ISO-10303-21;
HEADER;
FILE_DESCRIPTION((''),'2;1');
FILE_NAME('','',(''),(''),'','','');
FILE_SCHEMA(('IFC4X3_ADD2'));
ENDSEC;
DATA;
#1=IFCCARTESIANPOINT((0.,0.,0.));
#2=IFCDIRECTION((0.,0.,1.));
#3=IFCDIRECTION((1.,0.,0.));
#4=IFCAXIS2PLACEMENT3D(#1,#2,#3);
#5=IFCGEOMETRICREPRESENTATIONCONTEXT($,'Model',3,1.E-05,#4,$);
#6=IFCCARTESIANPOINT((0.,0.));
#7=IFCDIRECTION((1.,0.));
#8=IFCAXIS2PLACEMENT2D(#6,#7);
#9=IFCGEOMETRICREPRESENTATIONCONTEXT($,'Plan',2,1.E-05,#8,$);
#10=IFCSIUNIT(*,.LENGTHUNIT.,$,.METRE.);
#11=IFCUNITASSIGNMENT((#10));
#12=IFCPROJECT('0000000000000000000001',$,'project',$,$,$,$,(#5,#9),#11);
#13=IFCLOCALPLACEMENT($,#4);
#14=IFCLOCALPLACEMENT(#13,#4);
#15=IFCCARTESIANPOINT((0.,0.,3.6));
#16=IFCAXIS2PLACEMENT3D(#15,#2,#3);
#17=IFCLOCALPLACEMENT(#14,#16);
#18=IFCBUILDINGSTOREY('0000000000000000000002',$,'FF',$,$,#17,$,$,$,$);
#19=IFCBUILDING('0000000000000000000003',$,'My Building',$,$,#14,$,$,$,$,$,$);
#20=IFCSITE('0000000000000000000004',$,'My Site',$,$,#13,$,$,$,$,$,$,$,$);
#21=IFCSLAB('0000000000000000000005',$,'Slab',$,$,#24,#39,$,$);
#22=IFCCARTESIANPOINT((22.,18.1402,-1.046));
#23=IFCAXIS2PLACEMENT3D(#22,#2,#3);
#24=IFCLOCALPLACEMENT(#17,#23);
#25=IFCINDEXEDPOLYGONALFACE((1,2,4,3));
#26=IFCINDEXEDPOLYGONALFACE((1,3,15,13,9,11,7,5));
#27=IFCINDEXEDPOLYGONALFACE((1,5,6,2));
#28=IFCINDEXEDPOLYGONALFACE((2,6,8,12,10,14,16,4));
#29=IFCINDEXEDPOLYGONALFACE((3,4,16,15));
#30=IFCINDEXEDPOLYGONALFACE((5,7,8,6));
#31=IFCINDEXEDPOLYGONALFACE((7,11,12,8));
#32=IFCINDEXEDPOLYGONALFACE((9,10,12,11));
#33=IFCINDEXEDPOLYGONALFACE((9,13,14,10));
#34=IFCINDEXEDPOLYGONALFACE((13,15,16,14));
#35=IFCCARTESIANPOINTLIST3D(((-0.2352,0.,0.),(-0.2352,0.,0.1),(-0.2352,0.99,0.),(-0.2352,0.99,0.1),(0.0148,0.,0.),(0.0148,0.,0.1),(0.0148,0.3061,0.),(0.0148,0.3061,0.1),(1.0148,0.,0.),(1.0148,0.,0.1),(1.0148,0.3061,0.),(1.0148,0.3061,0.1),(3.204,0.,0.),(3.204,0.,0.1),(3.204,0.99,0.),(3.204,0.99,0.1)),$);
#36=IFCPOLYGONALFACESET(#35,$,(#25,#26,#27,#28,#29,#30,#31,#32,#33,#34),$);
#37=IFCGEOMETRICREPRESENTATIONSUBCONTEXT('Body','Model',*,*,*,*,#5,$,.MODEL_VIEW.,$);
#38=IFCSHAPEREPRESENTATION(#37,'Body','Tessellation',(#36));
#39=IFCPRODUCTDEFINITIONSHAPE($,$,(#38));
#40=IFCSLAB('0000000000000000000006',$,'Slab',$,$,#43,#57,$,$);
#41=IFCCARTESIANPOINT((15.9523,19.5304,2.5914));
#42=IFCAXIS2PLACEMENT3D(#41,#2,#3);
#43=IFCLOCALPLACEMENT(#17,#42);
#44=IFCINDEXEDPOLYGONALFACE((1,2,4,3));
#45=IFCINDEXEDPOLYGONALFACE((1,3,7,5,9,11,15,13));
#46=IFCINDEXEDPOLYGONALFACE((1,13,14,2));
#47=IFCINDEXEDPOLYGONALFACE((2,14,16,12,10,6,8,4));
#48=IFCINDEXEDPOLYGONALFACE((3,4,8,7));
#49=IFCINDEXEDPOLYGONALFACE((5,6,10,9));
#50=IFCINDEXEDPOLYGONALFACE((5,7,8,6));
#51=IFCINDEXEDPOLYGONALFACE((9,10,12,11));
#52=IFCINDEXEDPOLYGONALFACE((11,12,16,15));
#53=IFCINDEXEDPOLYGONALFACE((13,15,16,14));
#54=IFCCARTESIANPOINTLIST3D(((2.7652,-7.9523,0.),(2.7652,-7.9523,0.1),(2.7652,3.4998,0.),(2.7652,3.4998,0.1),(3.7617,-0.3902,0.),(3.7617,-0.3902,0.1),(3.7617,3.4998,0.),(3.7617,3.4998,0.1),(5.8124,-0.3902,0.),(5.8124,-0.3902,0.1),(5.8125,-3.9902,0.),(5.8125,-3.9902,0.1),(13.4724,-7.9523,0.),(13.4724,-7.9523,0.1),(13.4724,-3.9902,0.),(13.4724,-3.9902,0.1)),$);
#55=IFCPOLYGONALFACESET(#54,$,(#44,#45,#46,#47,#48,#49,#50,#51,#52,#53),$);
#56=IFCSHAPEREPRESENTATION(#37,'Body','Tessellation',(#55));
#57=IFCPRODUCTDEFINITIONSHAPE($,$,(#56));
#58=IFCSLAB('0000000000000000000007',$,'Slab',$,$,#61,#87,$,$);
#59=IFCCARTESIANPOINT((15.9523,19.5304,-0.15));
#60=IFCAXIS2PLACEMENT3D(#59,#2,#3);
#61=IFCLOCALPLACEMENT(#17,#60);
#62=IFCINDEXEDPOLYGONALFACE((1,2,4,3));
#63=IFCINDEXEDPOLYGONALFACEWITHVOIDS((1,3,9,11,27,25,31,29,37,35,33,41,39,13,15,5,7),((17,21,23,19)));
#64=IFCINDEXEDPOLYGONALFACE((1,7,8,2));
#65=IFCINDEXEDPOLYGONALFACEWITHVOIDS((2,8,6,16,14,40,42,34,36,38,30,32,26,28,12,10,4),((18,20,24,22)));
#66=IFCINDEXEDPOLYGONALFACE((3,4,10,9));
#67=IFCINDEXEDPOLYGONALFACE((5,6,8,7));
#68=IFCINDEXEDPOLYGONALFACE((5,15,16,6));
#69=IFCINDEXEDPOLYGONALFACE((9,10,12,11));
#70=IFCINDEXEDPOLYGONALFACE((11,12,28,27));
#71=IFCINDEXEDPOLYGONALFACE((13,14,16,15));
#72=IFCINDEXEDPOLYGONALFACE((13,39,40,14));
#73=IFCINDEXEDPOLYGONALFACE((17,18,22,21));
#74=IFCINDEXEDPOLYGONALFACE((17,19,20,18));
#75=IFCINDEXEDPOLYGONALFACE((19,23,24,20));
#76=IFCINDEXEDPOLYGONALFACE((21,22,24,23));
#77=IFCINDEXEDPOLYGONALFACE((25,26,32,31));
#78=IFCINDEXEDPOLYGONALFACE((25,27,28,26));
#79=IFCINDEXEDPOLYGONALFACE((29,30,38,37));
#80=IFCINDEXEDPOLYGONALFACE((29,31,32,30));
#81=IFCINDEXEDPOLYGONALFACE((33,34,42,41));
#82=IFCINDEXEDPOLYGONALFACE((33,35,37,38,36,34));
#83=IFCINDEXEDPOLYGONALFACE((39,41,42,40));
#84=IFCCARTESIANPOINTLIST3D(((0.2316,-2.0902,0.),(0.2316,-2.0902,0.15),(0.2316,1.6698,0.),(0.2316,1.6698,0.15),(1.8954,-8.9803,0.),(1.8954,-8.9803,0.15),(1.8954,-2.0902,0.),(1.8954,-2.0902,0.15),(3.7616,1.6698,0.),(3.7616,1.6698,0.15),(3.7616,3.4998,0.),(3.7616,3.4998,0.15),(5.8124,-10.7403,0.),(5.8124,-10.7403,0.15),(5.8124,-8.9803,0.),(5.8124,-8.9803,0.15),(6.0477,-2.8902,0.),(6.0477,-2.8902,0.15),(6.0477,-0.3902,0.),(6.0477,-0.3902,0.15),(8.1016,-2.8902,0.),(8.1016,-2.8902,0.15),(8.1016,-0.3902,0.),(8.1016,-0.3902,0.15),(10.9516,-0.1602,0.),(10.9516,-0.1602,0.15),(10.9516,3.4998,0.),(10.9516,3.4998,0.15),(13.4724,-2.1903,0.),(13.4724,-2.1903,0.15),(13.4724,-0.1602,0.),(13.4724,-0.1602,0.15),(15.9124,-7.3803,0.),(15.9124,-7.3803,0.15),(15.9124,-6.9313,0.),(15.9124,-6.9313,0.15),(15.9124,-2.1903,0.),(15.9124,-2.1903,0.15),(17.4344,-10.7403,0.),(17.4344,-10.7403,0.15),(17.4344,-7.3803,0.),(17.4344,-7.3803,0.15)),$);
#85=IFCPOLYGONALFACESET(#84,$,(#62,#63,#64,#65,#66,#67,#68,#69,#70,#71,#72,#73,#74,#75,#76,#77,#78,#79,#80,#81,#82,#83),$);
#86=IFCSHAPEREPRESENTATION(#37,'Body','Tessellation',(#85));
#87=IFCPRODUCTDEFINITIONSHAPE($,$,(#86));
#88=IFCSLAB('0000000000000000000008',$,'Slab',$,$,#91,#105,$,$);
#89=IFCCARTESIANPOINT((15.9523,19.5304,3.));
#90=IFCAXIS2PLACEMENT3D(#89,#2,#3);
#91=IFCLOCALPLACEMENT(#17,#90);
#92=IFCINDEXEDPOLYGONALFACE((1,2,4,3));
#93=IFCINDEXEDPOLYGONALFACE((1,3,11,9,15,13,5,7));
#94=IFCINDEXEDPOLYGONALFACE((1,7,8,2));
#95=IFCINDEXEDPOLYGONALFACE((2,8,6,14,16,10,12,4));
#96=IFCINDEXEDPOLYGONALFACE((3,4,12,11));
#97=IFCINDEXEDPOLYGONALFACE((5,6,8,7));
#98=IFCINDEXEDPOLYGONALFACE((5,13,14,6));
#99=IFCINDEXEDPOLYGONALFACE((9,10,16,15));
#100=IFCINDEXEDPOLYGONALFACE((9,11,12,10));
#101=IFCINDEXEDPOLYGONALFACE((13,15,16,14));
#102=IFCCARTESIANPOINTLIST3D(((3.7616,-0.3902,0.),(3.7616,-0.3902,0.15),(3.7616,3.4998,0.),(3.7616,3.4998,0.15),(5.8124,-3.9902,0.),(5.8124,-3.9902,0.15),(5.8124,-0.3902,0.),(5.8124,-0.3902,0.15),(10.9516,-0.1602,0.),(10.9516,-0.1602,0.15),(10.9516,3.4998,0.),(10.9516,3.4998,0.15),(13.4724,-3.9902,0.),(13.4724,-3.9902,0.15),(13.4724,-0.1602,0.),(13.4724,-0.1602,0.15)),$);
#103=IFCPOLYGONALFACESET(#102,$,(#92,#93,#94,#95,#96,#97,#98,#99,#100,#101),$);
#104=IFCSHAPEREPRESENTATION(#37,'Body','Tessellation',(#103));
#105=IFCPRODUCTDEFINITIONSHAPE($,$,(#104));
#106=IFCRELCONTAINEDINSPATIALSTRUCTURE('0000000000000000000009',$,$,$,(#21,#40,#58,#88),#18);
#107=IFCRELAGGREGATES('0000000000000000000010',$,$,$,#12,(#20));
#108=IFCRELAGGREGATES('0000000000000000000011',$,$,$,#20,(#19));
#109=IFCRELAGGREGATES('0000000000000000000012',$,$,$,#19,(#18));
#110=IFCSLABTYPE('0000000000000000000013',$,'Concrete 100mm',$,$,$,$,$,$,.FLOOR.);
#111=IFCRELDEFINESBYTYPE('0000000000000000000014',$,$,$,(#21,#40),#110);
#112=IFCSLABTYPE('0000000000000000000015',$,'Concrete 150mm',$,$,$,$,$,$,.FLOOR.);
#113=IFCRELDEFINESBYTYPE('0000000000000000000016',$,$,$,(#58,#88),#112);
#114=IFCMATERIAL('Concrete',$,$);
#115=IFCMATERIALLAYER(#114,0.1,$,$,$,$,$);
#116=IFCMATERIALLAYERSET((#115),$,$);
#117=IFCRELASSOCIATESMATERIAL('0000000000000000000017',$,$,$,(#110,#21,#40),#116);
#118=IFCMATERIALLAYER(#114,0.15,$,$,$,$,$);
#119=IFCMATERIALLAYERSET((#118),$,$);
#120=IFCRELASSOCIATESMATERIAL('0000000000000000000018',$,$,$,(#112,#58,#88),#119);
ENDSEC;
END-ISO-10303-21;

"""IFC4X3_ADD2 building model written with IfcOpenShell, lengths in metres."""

from ifc_helpers import new_model, si_unit, frame, origin_with_axes, origin_2d_with_axis, place, context, subcontext, project, spatial, line, indexed_curve, outline, extrude, material, layer, layer_set, layer_usage, type_object, element, save


model = new_model("IFC4X3_ADD2")

# Units and contexts
model_context = context("Model", 3, precision=1e-05, world=origin_with_axes())
plan_context = context("Plan", 2, precision=1e-05, world=origin_2d_with_axis())
body_context_1 = subcontext(model_context, "Body", "Model", "MODEL_VIEW")
ifc_project = project(units=[si_unit("LENGTHUNIT", "METRE")], contexts=[model_context, plan_context])

# Site, building, storey
site_placement = place(None, origin_with_axes())
site = spatial("IfcSite", under=ifc_project, at=site_placement, Name="My Site")
building_placement = place(site_placement, origin_with_axes())
building = spatial("IfcBuilding", under=site, at=building_placement, Name="My Building")
storey_placement = place(building_placement, frame((0.0, 0.0, 3.6), z_axis=(0.0, 0.0, 1.0), x_axis=(1.0, 0.0, 0.0)))
storey = spatial("IfcBuildingStorey", under=building, at=storey_placement, Name="FF")

# Slabs
ifc_material_1 = material(Name="Concrete")
ifc_layer_1 = layer(ifc_material_1, 0.1)
ifc_layer_set_1 = layer_set([ifc_layer_1])
ifc_layer_usage_1 = layer_usage(ifc_layer_set_1, "AXIS3", "POSITIVE", 0.0)
slab_type_1 = type_object("IfcSlabType", Name="Concrete 100mm", PredefinedType="FLOOR", material=ifc_layer_set_1)
slab_1_placement = place(storey_placement, frame((22.0, 18.1402, -1.046), z_axis=(0.0, 0.0, 1.0), x_axis=(1.0, 0.0, 0.0)))
element("IfcSlab", 1, at=slab_1_placement, inside=storey, type_object=slab_type_1, material=ifc_layer_usage_1, Name="Slab", context=body_context_1, shape_type="SweptSolid", body=[
    extrude(outline(indexed_curve([(-0.2352, 0.99), (3.204, 0.99), (3.204, 0.0), (1.0148, 0.0), (1.0148, 0.3061), (0.0148, 0.3061), (0.0148, 0.0), (-0.2352, 0.0), (-0.2352, 0.99)])), None, (0.0, 0.0, 1.0), 0.1),
])
ifc_layer_usage_2 = layer_usage(ifc_layer_set_1, "AXIS3", "POSITIVE", 0.0)
slab_2_placement = place(storey_placement, frame((15.9523, 19.5304, 2.5914), z_axis=(0.0, 0.0, 1.0), x_axis=(1.0, 0.0, 0.0)))
element("IfcSlab", 2, at=slab_2_placement, inside=storey, type_object=slab_type_1, material=ifc_layer_usage_2, Name="Slab", context=body_context_1, shape_type="SweptSolid", body=[
    extrude(outline(indexed_curve([(13.4724, -7.9523), (13.4724, -3.9902), (5.8125, -3.9902), (5.8124, -0.3902), (3.7617, -0.3902), (3.7617, 3.4998), (2.7652, 3.4998), (2.7652, -7.9523)], segments=[line(5, 6), line(6, 7), line(7, 8), line(8, 1), line(1, 2), line(2, 3), line(3, 4), line(4, 5)], self_intersect=False)), None, (0.0, 0.0, 1.0), 0.1),
])
ifc_layer_2 = layer(ifc_material_1, 0.15)
ifc_layer_set_2 = layer_set([ifc_layer_2])
ifc_layer_usage_3 = layer_usage(ifc_layer_set_2, "AXIS3", "POSITIVE", 0.0)
slab_type_2 = type_object("IfcSlabType", Name="Concrete 150mm", PredefinedType="FLOOR", material=ifc_layer_set_2)
slab_3_placement = place(storey_placement, frame((15.9523, 19.5304, -0.15), z_axis=(0.0, 0.0, 1.0), x_axis=(1.0, 0.0, 0.0)))
element("IfcSlab", 3, at=slab_3_placement, inside=storey, type_object=slab_type_2, material=ifc_layer_usage_3, Name="Slab", context=body_context_1, shape_type="SweptSolid", body=[
    extrude(outline(indexed_curve([(5.8124, -8.9803), (1.8954, -8.9803), (1.8954, -2.0902), (0.2316, -2.0902), (0.2316, 1.6698), (3.7616, 1.6698), (3.7616, 3.4998), (10.9516, 3.4998), (10.9516, -0.1602), (13.4724, -0.1602), (13.4724, -2.1903), (15.9124, -2.1903), (15.9124, -6.9313), (15.9124, -7.3803), (17.4344, -7.3803), (17.4344, -10.7403), (5.8124, -10.7403), (5.8124, -8.9803)]), holes=[indexed_curve([(8.1016, -0.3902), (6.0477, -0.3902), (6.0477, -2.8902), (8.1016, -2.8902), (8.1016, -0.3902)])]), None, (0.0, 0.0, 1.0), 0.15),
])
ifc_layer_usage_4 = layer_usage(ifc_layer_set_2, "AXIS3", "POSITIVE", 0.0)
slab_4_placement = place(storey_placement, frame((15.9523, 19.5304, 3.0), z_axis=(0.0, 0.0, 1.0), x_axis=(1.0, 0.0, 0.0)))
element("IfcSlab", 4, at=slab_4_placement, inside=storey, type_object=slab_type_2, material=ifc_layer_usage_4, Name="Slab", context=body_context_1, shape_type="SweptSolid", body=[
    extrude(outline(indexed_curve([(5.8124, -0.3902), (3.7616, -0.3902), (3.7616, 3.4998), (10.9516, 3.4998), (10.9516, -0.1602), (13.4724, -0.1602), (13.4724, -3.9902), (5.8124, -3.9902)], segments=[line(3, 2), line(2, 1), line(1, 8), line(8, 7), line(7, 6), line(6, 5), line(5, 4), line(4, 3)], self_intersect=False)), None, (0.0, 0.0, 1.0), 0.15),
])

save(model, "model.ifc")
